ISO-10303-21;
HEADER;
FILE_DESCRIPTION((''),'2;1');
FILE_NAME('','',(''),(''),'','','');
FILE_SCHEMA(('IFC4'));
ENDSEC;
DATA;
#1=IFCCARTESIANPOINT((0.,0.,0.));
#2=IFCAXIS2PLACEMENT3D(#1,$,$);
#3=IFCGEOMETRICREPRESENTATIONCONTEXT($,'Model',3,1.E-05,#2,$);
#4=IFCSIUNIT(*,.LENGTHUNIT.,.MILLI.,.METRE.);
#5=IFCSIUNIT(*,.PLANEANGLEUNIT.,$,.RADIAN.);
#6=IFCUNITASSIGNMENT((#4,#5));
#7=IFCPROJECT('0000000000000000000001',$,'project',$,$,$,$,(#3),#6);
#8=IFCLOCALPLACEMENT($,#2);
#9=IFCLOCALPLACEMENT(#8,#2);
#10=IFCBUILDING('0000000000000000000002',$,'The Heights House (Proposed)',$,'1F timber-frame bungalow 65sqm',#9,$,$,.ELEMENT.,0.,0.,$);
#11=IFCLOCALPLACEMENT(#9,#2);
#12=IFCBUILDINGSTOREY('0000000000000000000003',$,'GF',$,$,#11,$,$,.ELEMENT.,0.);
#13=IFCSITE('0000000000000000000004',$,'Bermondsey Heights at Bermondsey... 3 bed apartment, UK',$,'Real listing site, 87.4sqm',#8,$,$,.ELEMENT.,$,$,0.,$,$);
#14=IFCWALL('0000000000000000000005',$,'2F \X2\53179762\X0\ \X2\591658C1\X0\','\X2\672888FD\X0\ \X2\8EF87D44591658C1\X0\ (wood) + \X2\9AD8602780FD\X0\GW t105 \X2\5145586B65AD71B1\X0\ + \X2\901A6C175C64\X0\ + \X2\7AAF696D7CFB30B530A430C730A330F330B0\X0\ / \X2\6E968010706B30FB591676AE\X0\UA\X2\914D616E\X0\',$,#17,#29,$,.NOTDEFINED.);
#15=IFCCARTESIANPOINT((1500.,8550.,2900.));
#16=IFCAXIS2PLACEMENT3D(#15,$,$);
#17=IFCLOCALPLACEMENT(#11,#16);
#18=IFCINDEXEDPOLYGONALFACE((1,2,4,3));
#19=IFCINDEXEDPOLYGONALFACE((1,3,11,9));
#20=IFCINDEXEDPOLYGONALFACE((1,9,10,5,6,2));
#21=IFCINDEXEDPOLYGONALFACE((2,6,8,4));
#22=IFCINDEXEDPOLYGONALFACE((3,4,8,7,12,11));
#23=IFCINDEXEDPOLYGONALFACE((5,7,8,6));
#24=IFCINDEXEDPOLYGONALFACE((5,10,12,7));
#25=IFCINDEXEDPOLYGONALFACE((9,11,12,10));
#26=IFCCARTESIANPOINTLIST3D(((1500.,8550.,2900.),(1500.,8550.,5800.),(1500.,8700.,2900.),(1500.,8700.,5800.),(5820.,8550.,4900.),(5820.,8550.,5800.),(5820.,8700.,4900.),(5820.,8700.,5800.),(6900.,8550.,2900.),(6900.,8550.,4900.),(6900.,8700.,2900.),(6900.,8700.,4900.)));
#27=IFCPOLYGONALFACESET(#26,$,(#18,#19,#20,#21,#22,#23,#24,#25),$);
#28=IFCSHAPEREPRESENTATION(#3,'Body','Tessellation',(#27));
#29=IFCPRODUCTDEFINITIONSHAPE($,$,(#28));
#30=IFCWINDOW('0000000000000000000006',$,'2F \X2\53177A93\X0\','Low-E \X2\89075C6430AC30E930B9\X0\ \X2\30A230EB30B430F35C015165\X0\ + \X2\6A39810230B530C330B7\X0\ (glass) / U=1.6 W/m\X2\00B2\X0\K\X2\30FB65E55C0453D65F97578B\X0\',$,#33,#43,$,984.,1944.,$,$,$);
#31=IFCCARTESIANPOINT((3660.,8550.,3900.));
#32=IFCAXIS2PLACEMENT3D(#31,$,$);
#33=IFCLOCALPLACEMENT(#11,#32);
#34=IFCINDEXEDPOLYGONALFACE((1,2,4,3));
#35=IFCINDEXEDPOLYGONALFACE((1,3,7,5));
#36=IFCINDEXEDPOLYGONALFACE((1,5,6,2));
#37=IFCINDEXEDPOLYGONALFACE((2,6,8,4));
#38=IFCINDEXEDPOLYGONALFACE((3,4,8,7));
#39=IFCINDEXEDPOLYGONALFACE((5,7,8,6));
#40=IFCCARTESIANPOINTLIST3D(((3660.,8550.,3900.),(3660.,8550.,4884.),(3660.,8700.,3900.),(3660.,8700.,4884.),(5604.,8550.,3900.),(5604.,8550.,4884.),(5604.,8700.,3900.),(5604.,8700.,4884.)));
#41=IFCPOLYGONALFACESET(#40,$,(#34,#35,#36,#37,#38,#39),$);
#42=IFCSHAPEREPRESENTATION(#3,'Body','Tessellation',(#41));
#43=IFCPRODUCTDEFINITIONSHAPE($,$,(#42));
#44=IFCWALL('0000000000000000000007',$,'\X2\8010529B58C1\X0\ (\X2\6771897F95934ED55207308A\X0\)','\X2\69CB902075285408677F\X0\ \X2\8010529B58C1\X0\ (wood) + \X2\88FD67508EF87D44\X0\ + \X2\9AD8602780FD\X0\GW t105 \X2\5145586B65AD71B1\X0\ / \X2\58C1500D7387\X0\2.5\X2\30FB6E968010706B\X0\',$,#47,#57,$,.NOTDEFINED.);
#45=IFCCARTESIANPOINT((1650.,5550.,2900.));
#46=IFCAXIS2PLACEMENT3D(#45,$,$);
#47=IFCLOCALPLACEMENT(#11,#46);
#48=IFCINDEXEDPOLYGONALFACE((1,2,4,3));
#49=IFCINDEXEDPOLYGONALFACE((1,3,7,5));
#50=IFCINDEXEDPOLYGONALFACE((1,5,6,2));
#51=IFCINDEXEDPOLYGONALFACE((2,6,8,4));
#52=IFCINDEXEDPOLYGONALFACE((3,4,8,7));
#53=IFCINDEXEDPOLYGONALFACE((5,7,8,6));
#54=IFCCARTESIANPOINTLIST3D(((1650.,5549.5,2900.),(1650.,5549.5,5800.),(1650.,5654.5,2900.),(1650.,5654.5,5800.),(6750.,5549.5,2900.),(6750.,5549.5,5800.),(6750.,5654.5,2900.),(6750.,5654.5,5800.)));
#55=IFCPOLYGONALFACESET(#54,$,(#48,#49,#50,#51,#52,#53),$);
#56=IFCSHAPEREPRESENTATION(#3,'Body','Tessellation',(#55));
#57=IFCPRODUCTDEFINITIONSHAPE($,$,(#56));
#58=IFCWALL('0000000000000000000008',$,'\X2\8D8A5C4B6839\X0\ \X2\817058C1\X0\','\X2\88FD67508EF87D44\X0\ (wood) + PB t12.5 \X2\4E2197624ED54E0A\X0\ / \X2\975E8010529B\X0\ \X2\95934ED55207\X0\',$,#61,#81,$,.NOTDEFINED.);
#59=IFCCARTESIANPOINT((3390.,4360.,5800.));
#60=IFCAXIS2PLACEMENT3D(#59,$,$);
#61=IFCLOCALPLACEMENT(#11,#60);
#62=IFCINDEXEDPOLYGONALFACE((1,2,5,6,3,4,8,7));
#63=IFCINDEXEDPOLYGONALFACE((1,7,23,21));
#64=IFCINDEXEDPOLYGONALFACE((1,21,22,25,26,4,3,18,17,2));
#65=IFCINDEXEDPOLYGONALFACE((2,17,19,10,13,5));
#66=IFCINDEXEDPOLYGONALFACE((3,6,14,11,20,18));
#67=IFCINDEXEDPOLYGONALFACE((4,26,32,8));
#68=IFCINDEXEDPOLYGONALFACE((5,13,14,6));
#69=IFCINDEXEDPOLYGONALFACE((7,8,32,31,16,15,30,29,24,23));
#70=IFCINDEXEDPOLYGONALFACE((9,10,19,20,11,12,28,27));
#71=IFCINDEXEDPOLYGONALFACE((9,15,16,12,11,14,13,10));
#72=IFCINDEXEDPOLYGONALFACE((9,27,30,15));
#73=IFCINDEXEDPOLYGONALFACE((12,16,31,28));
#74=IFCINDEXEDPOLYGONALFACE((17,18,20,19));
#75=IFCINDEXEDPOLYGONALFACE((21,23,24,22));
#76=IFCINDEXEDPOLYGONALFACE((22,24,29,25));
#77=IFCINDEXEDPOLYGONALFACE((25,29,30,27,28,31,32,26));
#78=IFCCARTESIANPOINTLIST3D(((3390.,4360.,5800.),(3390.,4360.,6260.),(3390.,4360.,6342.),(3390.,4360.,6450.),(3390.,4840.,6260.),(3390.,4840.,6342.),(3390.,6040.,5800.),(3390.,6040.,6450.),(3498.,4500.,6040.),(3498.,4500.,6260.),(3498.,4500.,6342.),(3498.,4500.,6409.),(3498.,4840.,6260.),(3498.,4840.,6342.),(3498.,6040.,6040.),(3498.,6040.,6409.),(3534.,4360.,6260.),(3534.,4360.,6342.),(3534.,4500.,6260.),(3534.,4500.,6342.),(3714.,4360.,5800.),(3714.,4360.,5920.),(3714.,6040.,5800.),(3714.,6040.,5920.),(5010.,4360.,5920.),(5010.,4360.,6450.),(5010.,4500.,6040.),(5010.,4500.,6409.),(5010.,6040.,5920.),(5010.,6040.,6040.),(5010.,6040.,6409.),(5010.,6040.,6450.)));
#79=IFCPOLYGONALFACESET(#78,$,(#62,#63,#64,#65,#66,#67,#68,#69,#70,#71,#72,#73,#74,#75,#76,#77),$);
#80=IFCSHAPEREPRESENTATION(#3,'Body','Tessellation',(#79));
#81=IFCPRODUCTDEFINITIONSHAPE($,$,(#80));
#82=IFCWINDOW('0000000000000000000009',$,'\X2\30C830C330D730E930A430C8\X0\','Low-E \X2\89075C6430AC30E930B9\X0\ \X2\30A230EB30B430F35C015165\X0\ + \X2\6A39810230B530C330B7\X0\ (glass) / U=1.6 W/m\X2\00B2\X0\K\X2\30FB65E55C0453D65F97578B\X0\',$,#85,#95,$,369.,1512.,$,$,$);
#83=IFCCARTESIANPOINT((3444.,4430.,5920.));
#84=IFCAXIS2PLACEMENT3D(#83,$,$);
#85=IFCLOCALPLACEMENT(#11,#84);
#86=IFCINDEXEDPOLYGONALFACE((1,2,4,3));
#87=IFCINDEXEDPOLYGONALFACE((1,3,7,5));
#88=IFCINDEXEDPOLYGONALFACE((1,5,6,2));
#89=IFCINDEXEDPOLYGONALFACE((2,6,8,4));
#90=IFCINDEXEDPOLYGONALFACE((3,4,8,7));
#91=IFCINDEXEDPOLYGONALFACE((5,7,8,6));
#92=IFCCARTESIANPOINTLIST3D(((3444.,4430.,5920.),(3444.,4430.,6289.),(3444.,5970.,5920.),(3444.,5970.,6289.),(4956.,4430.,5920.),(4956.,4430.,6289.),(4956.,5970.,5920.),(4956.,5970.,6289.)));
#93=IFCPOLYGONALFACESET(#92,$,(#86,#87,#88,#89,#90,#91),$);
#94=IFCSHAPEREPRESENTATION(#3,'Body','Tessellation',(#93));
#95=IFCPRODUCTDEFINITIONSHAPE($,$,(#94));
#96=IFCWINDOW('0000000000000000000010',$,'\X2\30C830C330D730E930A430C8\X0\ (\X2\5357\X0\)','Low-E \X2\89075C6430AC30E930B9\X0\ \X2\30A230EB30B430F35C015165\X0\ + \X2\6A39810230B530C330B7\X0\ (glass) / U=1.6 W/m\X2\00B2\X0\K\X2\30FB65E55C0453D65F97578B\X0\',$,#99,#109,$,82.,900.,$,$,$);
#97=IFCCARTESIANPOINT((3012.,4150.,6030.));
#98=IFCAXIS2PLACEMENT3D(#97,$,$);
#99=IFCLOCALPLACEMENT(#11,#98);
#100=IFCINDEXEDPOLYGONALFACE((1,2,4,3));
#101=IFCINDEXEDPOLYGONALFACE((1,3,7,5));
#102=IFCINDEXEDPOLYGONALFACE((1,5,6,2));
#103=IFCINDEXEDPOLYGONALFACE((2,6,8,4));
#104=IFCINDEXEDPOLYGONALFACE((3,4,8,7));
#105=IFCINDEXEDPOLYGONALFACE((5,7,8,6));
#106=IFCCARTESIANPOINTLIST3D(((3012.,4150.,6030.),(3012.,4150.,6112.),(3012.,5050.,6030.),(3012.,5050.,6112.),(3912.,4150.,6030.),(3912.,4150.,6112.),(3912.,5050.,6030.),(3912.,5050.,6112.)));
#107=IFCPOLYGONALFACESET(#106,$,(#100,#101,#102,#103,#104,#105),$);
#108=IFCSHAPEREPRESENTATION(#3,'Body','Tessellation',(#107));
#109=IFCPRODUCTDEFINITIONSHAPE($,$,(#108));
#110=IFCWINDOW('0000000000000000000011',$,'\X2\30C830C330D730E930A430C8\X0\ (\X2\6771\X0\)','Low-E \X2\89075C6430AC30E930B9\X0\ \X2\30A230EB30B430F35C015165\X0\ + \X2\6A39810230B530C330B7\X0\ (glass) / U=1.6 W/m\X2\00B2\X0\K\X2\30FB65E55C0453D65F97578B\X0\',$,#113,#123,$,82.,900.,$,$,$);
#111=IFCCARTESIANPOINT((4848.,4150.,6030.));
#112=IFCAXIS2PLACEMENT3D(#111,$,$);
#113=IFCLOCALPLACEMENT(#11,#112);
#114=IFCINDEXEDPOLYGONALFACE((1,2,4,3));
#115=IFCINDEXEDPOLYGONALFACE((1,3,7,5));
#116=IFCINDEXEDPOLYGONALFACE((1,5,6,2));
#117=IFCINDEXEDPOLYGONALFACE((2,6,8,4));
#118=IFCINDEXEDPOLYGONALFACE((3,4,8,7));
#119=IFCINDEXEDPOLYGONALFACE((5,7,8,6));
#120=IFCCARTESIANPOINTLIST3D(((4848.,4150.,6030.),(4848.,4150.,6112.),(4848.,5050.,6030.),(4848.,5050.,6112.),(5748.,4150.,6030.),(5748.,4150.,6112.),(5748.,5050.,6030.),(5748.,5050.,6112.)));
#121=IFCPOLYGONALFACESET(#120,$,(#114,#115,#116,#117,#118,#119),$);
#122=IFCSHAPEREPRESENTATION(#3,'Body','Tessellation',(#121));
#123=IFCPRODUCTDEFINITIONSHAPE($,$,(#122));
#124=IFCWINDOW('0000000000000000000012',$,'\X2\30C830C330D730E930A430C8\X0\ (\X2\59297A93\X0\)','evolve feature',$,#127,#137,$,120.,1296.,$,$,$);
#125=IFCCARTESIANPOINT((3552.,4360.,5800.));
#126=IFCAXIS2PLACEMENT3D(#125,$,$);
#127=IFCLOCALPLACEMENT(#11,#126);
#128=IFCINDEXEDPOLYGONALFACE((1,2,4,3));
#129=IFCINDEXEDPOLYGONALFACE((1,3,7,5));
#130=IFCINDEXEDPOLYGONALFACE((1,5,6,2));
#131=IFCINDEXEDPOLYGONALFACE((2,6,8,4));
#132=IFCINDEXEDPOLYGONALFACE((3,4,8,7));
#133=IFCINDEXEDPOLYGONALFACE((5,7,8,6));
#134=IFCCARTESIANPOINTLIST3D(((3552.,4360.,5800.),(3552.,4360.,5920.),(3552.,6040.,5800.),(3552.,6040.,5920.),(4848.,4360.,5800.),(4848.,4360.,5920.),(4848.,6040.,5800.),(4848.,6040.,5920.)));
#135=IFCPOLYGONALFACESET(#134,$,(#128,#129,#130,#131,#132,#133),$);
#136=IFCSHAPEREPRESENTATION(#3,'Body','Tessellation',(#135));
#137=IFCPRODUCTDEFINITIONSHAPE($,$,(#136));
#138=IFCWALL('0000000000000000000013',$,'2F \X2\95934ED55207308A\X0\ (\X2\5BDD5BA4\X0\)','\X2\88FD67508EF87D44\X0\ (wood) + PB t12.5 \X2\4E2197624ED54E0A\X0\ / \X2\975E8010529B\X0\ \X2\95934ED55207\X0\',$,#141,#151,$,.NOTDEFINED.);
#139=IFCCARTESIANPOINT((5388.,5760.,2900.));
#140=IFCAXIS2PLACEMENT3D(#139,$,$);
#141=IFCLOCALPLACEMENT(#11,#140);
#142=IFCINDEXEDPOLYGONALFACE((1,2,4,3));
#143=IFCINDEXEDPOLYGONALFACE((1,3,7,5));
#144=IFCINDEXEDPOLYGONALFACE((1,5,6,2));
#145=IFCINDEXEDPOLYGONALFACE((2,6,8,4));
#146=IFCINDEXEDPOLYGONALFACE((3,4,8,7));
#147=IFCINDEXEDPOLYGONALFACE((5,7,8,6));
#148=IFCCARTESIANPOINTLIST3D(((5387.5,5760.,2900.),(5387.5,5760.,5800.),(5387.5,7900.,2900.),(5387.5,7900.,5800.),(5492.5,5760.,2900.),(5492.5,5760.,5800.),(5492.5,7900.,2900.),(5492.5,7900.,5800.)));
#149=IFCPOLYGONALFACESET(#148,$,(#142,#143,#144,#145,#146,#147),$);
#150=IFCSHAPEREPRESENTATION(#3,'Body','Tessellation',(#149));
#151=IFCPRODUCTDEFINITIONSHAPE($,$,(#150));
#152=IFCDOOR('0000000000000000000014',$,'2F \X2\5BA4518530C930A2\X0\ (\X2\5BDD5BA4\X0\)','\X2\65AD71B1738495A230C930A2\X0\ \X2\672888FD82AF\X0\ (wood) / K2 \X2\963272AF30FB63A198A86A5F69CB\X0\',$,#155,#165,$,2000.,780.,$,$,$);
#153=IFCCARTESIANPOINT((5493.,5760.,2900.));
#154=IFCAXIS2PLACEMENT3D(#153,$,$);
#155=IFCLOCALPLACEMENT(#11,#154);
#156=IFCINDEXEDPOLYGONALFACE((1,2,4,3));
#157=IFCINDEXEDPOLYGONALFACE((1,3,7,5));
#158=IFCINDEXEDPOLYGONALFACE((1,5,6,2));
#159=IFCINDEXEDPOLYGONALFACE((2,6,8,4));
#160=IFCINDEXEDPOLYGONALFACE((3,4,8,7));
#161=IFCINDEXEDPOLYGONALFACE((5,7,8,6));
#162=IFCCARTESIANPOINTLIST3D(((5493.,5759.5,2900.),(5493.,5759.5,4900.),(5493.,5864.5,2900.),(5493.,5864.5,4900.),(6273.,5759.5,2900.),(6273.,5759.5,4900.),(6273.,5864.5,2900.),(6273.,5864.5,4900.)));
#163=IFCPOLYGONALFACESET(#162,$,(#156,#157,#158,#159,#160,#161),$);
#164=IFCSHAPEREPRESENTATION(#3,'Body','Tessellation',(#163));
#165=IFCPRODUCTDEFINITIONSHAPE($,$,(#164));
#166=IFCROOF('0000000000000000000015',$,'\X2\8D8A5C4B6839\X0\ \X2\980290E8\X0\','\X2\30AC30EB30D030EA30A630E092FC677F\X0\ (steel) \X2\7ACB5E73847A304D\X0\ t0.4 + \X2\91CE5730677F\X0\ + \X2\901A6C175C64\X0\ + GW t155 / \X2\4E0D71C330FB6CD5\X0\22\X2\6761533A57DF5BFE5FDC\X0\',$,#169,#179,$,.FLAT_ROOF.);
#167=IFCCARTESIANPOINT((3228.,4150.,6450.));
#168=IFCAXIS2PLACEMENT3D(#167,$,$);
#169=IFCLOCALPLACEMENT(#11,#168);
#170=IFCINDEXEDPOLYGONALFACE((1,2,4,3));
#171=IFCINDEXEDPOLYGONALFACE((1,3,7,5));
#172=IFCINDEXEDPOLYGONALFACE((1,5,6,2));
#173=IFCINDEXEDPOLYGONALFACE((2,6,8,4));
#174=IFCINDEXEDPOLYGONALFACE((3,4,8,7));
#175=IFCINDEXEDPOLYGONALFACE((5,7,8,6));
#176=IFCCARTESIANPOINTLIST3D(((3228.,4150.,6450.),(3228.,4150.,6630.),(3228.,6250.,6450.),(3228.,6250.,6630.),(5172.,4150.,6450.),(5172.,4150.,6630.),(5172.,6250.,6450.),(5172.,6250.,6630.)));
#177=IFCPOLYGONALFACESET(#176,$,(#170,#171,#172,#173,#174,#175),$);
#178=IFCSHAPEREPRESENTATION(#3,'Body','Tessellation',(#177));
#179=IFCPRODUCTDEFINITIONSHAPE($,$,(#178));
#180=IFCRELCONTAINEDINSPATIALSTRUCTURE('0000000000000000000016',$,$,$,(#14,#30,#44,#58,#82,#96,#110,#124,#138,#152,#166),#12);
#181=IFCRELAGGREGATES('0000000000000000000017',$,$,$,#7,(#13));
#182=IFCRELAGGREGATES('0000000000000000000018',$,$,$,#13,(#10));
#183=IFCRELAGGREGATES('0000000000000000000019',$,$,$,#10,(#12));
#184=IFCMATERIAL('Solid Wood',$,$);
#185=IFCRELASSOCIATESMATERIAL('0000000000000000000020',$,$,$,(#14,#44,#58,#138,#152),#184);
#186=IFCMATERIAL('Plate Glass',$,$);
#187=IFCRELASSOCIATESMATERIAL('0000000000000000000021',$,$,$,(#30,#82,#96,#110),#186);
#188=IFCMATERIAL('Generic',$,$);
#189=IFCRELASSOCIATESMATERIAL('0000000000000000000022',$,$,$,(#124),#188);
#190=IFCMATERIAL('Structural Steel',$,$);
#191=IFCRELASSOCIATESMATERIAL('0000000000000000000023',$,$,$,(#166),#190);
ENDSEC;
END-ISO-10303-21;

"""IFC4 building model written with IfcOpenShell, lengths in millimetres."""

from ifc_helpers import new_model, si_unit, frame, frame_2d, origin, place, context, project, spatial, rectangle, extrude, material, element, fill, save


model = new_model("IFC4")

# Units and contexts
model_context = context("Model", 3, precision=1e-05, world=origin())
ifc_project = project(units=[si_unit("LENGTHUNIT", "METRE", prefix="MILLI"), si_unit("PLANEANGLEUNIT", "RADIAN")], contexts=[model_context])

# Site, building, storey
site_placement = place(None, origin())
site = spatial("IfcSite", under=ifc_project, at=site_placement, Name="Bermondsey Heights at Bermondsey... 3 bed apartment, UK", ObjectType="Real listing site, 87.4sqm", CompositionType="ELEMENT", RefElevation=0.0)
building_placement = place(site_placement, origin())
building = spatial("IfcBuilding", under=site, at=building_placement, Name="The Heights House (Proposed)", ObjectType="1F timber-frame bungalow 65sqm", CompositionType="ELEMENT", ElevationOfRefHeight=0.0, ElevationOfTerrain=0.0)
storey_placement = place(building_placement, origin())
storey = spatial("IfcBuildingStorey", under=building, at=storey_placement, Name="GF", CompositionType="ELEMENT", Elevation=0.0)

# Wall, opening, window
ifc_material_1 = material(Name="Solid Wood")
wall_1_placement = place(storey_placement, frame((1500.0, 8550.0, 2900.0)))
wall_1 = element("IfcWall", 1, at=wall_1_placement, inside=storey, material=ifc_material_1, Name="2F 北面 外壁", Description="木製 軸組外壁 (wood) + 高性能GW t105 充填断熱 + 通気層 + 窯業系サイディング / 準耐火・外皮UA配慮", PredefinedType="NOTDEFINED", context=model_context, shape_type="SweptSolid", body=[
    extrude(rectangle(XDim=5400.0, YDim=150.0, at=frame_2d((2700.0, 75.0))), frame((1500.0, 8550.0, 2900.0)), (0.0, 0.0, 1.0), 2900.0),
])
opening_1_placement = place(storey_placement, frame((3660.0, 8550.0, 3900.0)))
opening_1 = element("IfcOpeningElement", 2, at=opening_1_placement, cuts=wall_1, PredefinedType="NOTDEFINED", context=model_context, shape_type="SweptSolid", body=[
    extrude(rectangle(XDim=1944.0, YDim=150.0, at=frame_2d((972.0, 75.0))), frame((3660.0, 8550.0, 3900.0)), (0.0, 0.0, 1.0), 984.0),
])
ifc_material_2 = material(Name="Plate Glass")
window_1_placement = place(storey_placement, frame((3660.0, 8550.0, 3900.0)))
window_1 = element("IfcWindow", 3, at=window_1_placement, inside=storey, material=ifc_material_2, Name="2F 北窓", Description="Low-E 複層ガラス アルゴン封入 + 樹脂サッシ (glass) / U=1.6 W/m²K・日射取得型", OverallHeight=984.0, OverallWidth=1944.0, context=model_context, shape_type="SweptSolid", body=[
    extrude(rectangle(XDim=1944.0, YDim=150.0, at=frame_2d((972.0, 75.0))), frame((3660.0, 8550.0, 3900.0)), (0.0, 0.0, 1.0), 984.0),
])
fill(opening_1, window_1)

# Wall
wall_2_placement = place(storey_placement, frame((1650.0, 5550.0, 2900.0)))
element("IfcWall", 4, at=wall_2_placement, inside=storey, material=ifc_material_1, Name="耐力壁 (東西間仕切り)", Description="構造用合板 耐力壁 (wood) + 製材軸組 + 高性能GW t105 充填断熱 / 壁倍率2.5・準耐火", PredefinedType="NOTDEFINED", context=model_context, shape_type="SweptSolid", body=[
    extrude(rectangle(XDim=5100.0, YDim=105.0, at=frame_2d((2550.0, 52.0))), frame((1650.0, 5550.0, 2900.0)), (0.0, 0.0, 1.0), 2900.0),
])

# Wall, openings, windows
wall_3_placement = place(storey_placement, frame((3390.0, 4360.0, 5800.0)))
wall_3 = element("IfcWall", 5, at=wall_3_placement, inside=storey, material=ifc_material_1, Name="越屋根 腰壁", Description="製材軸組 (wood) + PB t12.5 両面仕上 / 非耐力 間仕切", PredefinedType="NOTDEFINED", context=model_context, shape_type="SweptSolid", body=[
    extrude(rectangle(XDim=1620.0, YDim=1680.0, at=frame_2d((810.0, 840.0))), frame((3390.0, 4360.0, 5800.0)), (0.0, 0.0, 1.0), 650.0),
])
opening_2_placement = place(storey_placement, frame((3444.0, 4430.0, 5920.0)))
opening_2 = element("IfcOpeningElement", 6, at=opening_2_placement, cuts=wall_3, PredefinedType="NOTDEFINED", context=model_context, shape_type="SweptSolid", body=[
    extrude(rectangle(XDim=1512.0, YDim=1540.0, at=frame_2d((756.0, 770.0))), frame((3444.0, 4430.0, 5920.0)), (0.0, 0.0, 1.0), 369.0),
])
opening_3_placement = place(storey_placement, frame((3012.0, 4150.0, 6030.0)))
opening_3 = element("IfcOpeningElement", 7, at=opening_3_placement, cuts=wall_3, PredefinedType="NOTDEFINED", context=model_context, shape_type="SweptSolid", body=[
    extrude(rectangle(XDim=900.0, YDim=900.0, at=frame_2d((450.0, 450.0))), frame((3012.0, 4150.0, 6030.0)), (0.0, 0.0, 1.0), 82.0),
])
opening_4_placement = place(storey_placement, frame((4848.0, 4150.0, 6030.0)))
opening_4 = element("IfcOpeningElement", 8, at=opening_4_placement, cuts=wall_3, PredefinedType="NOTDEFINED", context=model_context, shape_type="SweptSolid", body=[
    extrude(rectangle(XDim=900.0, YDim=900.0, at=frame_2d((450.0, 450.0))), frame((4848.0, 4150.0, 6030.0)), (0.0, 0.0, 1.0), 82.0),
])
opening_5_placement = place(storey_placement, frame((3552.0, 4360.0, 5800.0)))
opening_5 = element("IfcOpeningElement", 9, at=opening_5_placement, cuts=wall_3, PredefinedType="NOTDEFINED", context=model_context, shape_type="SweptSolid", body=[
    extrude(rectangle(XDim=1296.0, YDim=1680.0, at=frame_2d((648.0, 840.0))), frame((3552.0, 4360.0, 5800.0)), (0.0, 0.0, 1.0), 120.0),
])
window_2_placement = place(storey_placement, frame((3444.0, 4430.0, 5920.0)))
window_2 = element("IfcWindow", 10, at=window_2_placement, inside=storey, material=ifc_material_2, Name="トップライト", Description="Low-E 複層ガラス アルゴン封入 + 樹脂サッシ (glass) / U=1.6 W/m²K・日射取得型", OverallHeight=369.0, OverallWidth=1512.0, context=model_context, shape_type="SweptSolid", body=[
    extrude(rectangle(XDim=1512.0, YDim=1540.0, at=frame_2d((756.0, 770.0))), frame((3444.0, 4430.0, 5920.0)), (0.0, 0.0, 1.0), 369.0),
])
fill(opening_2, window_2)
window_3_placement = place(storey_placement, frame((3012.0, 4150.0, 6030.0)))
window_3 = element("IfcWindow", 11, at=window_3_placement, inside=storey, material=ifc_material_2, Name="トップライト (南)", Description="Low-E 複層ガラス アルゴン封入 + 樹脂サッシ (glass) / U=1.6 W/m²K・日射取得型", OverallHeight=82.0, OverallWidth=900.0, context=model_context, shape_type="SweptSolid", body=[
    extrude(rectangle(XDim=900.0, YDim=900.0, at=frame_2d((450.0, 450.0))), frame((3012.0, 4150.0, 6030.0)), (0.0, 0.0, 1.0), 82.0),
])
fill(opening_3, window_3)
window_4_placement = place(storey_placement, frame((4848.0, 4150.0, 6030.0)))
window_4 = element("IfcWindow", 12, at=window_4_placement, inside=storey, material=ifc_material_2, Name="トップライト (東)", Description="Low-E 複層ガラス アルゴン封入 + 樹脂サッシ (glass) / U=1.6 W/m²K・日射取得型", OverallHeight=82.0, OverallWidth=900.0, context=model_context, shape_type="SweptSolid", body=[
    extrude(rectangle(XDim=900.0, YDim=900.0, at=frame_2d((450.0, 450.0))), frame((4848.0, 4150.0, 6030.0)), (0.0, 0.0, 1.0), 82.0),
])
fill(opening_4, window_4)
ifc_material_3 = material(Name="Generic")
window_5_placement = place(storey_placement, frame((3552.0, 4360.0, 5800.0)))
window_5 = element("IfcWindow", 13, at=window_5_placement, inside=storey, material=ifc_material_3, Name="トップライト (天窓)", Description="evolve feature", OverallHeight=120.0, OverallWidth=1296.0, context=model_context, shape_type="SweptSolid", body=[
    extrude(rectangle(XDim=1296.0, YDim=1680.0, at=frame_2d((648.0, 840.0))), frame((3552.0, 4360.0, 5800.0)), (0.0, 0.0, 1.0), 120.0),
])
fill(opening_5, window_5)

# Wall
wall_4_placement = place(storey_placement, frame((5388.0, 5760.0, 2900.0)))
element("IfcWall", 14, at=wall_4_placement, inside=storey, material=ifc_material_1, Name="2F 間仕切り (寝室)", Description="製材軸組 (wood) + PB t12.5 両面仕上 / 非耐力 間仕切", PredefinedType="NOTDEFINED", context=model_context, shape_type="SweptSolid", body=[
    extrude(rectangle(XDim=105.0, YDim=2140.0, at=frame_2d((52.0, 1070.0))), frame((5388.0, 5760.0, 2900.0)), (0.0, 0.0, 1.0), 2900.0),
])

# Door
door_placement = place(storey_placement, frame((5493.0, 5760.0, 2900.0)))
element("IfcDoor", 15, at=door_placement, inside=storey, material=ifc_material_1, Name="2F 室内ドア (寝室)", Description="断熱玄関ドア 木製芯 (wood) / K2 防犯・採風機構", OverallHeight=2000.0, OverallWidth=780.0, context=model_context, shape_type="SweptSolid", body=[
    extrude(rectangle(XDim=780.0, YDim=105.0, at=frame_2d((390.0, 52.0))), frame((5493.0, 5760.0, 2900.0)), (0.0, 0.0, 1.0), 2000.0),
])

# Roof
ifc_material_4 = material(Name="Structural Steel")
roof_placement = place(storey_placement, frame((3228.0, 4150.0, 6450.0)))
element("IfcRoof", 16, at=roof_placement, inside=storey, material=ifc_material_4, Name="越屋根 頂部", Description="ガルバリウム鋼板 (steel) 立平葺き t0.4 + 野地板 + 通気層 + GW t155 / 不燃・法22条区域対応", PredefinedType="FLAT_ROOF", context=model_context, shape_type="SweptSolid", body=[
    extrude(rectangle(XDim=1944.0, YDim=2100.0, at=frame_2d((972.0, 1050.0))), frame((3228.0, 4150.0, 6450.0)), (0.0, 0.0, 1.0), 180.0),
])

save(model, "model.ifc")
